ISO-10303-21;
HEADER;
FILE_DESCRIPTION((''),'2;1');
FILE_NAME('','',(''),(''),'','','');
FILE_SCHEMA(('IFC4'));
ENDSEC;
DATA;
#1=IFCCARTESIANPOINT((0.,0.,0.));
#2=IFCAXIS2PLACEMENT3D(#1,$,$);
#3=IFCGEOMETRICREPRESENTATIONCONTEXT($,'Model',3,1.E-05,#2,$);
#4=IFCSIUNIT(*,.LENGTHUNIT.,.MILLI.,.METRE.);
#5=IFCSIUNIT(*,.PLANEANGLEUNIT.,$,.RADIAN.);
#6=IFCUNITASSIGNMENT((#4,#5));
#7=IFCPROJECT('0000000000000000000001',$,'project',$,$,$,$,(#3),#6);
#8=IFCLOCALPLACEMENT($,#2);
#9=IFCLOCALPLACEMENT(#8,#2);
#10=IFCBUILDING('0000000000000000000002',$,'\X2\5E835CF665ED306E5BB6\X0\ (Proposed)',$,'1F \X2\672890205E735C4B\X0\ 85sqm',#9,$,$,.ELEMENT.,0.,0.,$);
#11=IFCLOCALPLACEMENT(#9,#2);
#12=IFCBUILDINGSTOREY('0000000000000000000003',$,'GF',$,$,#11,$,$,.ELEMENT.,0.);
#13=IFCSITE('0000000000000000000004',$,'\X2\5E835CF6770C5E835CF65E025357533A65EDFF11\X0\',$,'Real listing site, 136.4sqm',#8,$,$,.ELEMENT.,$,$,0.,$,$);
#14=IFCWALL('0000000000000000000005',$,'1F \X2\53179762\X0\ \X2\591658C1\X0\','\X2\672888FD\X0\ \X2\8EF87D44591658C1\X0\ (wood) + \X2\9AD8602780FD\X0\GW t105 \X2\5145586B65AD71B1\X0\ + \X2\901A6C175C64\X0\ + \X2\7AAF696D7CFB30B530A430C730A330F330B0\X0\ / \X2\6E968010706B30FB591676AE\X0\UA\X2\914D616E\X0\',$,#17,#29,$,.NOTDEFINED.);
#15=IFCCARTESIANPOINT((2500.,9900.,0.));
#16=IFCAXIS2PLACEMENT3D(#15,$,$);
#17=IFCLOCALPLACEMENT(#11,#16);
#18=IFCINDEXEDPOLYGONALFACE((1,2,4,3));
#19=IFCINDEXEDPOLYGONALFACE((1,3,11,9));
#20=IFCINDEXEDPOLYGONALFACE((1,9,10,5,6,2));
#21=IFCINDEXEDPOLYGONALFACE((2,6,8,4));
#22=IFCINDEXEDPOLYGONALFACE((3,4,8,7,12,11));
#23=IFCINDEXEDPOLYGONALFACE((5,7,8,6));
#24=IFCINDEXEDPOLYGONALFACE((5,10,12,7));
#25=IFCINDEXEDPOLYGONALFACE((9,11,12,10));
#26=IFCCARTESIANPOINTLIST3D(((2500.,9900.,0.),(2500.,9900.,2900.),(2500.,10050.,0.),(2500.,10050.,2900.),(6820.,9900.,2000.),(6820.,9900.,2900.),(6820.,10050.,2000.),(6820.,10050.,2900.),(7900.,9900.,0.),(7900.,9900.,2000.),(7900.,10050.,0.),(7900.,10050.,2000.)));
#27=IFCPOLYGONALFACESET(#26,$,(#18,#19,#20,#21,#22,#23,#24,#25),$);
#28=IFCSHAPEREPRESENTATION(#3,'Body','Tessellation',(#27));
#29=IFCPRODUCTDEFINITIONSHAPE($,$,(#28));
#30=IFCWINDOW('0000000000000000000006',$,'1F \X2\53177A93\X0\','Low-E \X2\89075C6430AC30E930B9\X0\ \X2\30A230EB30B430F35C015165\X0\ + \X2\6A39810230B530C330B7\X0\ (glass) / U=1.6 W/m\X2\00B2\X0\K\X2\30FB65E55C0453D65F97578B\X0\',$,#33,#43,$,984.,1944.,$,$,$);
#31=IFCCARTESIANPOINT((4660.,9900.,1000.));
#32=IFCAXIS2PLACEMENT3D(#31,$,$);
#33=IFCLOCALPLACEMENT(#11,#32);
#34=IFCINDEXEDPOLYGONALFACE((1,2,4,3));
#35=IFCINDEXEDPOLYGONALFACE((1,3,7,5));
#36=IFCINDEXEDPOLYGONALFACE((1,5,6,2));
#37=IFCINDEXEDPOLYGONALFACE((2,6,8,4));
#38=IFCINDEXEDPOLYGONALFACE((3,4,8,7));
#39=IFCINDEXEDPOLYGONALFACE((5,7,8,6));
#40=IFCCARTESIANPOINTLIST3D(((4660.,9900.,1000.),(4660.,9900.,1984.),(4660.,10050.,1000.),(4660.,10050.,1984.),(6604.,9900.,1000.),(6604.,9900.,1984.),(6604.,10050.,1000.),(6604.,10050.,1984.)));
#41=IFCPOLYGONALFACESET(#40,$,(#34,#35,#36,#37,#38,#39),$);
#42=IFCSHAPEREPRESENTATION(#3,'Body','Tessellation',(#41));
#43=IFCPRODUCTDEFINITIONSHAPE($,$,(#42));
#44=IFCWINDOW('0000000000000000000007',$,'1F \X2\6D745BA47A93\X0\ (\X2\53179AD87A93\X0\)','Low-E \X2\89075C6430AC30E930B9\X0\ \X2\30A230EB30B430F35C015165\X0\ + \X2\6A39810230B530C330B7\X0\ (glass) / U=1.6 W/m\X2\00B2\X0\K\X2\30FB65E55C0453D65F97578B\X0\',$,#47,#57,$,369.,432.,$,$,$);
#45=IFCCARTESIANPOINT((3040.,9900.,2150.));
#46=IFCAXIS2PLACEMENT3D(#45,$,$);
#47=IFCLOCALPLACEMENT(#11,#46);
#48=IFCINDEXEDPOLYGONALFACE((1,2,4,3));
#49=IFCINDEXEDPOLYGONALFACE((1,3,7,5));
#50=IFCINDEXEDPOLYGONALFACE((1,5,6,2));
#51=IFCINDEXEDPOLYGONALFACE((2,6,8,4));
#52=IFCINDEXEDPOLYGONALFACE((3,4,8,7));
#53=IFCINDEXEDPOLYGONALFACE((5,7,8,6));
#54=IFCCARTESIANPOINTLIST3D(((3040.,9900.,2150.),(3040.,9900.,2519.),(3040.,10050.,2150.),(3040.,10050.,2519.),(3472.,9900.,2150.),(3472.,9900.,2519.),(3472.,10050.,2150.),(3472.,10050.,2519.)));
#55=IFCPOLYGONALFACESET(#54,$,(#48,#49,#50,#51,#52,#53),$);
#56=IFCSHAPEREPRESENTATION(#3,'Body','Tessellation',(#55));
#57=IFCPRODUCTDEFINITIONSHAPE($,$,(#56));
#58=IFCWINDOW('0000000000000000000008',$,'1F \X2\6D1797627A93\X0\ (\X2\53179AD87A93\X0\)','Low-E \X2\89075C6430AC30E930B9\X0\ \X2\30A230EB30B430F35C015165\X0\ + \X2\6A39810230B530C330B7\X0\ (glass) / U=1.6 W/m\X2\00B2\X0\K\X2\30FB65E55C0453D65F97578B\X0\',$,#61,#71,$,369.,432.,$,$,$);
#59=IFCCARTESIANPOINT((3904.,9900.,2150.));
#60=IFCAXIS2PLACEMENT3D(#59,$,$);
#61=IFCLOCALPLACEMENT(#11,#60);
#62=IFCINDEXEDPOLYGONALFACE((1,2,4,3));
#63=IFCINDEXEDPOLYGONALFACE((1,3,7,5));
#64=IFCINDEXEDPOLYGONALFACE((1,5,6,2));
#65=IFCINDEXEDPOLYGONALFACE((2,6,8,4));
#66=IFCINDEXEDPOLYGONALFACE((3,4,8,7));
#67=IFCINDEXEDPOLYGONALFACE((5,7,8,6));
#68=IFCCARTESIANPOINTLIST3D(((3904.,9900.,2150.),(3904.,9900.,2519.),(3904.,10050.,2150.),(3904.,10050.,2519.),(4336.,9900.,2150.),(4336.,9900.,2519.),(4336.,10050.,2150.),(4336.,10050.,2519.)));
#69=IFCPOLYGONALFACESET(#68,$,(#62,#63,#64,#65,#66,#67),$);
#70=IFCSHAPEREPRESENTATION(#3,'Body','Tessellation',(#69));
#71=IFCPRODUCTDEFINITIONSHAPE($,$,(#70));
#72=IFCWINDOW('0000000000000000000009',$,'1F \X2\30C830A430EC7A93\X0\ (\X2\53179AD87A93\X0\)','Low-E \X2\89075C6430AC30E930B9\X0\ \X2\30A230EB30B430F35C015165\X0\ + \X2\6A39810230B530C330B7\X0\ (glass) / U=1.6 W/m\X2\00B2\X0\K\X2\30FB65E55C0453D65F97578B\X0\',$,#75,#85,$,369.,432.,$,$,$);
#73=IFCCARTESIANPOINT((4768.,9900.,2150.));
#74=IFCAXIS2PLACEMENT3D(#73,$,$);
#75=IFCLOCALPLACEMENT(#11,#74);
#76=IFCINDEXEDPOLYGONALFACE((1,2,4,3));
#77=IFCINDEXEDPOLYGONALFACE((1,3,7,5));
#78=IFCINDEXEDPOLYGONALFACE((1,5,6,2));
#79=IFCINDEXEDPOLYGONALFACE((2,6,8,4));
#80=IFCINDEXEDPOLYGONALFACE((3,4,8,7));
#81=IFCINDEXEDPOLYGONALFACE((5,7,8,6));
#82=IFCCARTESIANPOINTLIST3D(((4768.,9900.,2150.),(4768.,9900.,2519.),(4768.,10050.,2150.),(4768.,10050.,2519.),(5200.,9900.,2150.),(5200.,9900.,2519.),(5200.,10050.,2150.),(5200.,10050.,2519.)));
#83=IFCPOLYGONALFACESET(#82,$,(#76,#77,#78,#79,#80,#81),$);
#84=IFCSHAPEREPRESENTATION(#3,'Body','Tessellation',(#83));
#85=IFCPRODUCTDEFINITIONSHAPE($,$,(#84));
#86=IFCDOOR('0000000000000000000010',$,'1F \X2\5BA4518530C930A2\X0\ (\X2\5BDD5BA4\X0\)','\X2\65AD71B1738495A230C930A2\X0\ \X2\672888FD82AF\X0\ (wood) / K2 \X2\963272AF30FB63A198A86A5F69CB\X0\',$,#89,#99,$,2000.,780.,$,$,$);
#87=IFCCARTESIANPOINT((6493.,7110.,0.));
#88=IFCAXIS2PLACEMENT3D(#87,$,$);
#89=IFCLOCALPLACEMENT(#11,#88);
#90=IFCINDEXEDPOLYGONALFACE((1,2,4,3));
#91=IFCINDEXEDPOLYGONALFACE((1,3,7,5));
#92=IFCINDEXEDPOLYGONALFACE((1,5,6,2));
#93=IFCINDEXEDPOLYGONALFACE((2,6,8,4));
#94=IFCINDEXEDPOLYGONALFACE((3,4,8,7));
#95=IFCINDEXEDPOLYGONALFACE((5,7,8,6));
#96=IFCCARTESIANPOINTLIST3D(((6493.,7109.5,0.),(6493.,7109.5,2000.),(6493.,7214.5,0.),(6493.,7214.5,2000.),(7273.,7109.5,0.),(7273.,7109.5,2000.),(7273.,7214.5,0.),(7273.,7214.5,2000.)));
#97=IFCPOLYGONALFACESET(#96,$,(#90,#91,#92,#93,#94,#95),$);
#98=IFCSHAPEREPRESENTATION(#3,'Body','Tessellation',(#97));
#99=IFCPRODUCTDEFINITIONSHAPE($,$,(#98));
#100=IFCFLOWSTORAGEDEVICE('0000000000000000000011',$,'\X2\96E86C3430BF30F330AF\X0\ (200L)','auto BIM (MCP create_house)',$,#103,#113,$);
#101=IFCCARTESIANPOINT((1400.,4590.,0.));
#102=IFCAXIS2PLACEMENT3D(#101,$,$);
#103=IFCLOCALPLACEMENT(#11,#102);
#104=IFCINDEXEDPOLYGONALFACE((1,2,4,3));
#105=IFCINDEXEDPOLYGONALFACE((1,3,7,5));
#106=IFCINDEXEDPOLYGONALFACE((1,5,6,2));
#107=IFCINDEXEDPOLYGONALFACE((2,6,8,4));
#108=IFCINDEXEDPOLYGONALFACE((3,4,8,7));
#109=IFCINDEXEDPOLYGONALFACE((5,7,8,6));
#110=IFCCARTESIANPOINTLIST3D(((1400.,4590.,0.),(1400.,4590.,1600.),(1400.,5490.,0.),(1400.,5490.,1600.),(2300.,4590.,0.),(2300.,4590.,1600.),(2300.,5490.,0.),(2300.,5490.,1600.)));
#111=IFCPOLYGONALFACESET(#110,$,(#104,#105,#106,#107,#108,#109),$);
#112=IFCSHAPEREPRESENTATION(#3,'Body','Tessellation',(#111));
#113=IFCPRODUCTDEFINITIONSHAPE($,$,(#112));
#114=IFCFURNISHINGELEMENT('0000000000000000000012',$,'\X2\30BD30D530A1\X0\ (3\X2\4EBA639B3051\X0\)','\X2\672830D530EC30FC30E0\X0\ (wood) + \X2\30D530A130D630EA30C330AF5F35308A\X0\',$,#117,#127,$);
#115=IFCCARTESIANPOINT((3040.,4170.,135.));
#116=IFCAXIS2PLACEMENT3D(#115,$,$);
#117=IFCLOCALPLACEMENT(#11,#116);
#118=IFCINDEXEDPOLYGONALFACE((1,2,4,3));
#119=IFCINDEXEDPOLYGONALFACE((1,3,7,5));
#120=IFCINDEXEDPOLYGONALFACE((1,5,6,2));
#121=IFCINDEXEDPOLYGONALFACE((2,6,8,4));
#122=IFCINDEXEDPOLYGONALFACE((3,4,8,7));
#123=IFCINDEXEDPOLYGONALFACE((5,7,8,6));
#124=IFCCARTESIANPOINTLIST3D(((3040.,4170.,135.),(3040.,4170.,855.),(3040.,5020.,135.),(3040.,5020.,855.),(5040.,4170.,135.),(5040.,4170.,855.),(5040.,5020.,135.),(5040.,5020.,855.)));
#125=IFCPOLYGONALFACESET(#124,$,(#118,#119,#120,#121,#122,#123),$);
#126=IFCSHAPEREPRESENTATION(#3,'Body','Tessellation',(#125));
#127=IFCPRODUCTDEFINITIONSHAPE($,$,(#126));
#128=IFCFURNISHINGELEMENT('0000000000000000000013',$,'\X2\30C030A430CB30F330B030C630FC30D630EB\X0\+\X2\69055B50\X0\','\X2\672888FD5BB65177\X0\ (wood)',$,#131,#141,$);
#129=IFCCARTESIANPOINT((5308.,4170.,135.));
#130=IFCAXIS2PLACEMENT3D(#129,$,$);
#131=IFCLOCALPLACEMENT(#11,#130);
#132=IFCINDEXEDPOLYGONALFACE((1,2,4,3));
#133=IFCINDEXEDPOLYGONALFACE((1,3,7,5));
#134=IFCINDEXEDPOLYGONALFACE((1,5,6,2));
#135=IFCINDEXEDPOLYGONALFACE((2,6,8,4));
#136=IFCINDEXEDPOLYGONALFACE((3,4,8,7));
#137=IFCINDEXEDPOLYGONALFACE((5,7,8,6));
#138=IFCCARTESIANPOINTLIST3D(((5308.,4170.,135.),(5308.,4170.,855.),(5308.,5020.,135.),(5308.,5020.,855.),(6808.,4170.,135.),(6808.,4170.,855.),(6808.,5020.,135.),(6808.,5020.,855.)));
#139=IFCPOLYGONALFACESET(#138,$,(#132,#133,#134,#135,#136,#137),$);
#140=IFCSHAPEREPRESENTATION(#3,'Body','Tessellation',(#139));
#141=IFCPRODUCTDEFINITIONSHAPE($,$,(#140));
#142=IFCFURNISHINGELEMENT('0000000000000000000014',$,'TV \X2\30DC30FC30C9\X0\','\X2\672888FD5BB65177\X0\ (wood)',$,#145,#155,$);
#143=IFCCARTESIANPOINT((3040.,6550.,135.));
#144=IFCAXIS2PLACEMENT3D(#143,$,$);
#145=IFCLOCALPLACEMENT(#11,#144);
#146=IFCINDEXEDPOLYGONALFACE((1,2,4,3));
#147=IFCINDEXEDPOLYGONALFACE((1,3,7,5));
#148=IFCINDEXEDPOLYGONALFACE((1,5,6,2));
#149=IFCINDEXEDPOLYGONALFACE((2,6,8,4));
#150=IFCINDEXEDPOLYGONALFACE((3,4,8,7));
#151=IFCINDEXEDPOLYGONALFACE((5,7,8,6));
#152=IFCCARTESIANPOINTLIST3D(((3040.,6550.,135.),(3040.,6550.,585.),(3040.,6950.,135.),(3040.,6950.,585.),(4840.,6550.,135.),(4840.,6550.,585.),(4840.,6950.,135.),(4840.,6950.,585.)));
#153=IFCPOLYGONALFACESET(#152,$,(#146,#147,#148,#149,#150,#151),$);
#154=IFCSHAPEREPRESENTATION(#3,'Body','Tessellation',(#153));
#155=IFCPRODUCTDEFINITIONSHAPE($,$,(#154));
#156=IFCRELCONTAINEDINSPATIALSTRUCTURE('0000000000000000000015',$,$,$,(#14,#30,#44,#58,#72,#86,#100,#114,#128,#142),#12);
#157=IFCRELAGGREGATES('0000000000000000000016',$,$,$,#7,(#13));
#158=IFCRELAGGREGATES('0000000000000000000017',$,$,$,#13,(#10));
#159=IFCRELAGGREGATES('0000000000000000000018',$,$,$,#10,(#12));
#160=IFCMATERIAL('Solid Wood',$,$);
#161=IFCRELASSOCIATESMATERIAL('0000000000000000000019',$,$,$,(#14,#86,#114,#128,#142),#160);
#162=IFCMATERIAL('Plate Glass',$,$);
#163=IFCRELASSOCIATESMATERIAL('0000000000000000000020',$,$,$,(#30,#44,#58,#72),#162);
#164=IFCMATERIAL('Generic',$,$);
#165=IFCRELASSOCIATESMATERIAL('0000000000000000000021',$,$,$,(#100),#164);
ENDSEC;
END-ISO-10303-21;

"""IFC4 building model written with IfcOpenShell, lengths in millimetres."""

from ifc_helpers import new_model, si_unit, frame, frame_2d, origin, place, context, project, spatial, rectangle, extrude, material, element, fill, save


model = new_model("IFC4")

# Units and contexts
model_context = context("Model", 3, precision=1e-05, world=origin())
ifc_project = project(units=[si_unit("LENGTHUNIT", "METRE", prefix="MILLI"), si_unit("PLANEANGLEUNIT", "RADIAN")], contexts=[model_context])

# Site, building, storey
site_placement = place(None, origin())
site = spatial("IfcSite", under=ifc_project, at=site_placement, Name="広島県広島市南区旭１", ObjectType="Real listing site, 136.4sqm", CompositionType="ELEMENT", RefElevation=0.0)
building_placement = place(site_placement, origin())
building = spatial("IfcBuilding", under=site, at=building_placement, Name="広島旭の家 (Proposed)", ObjectType="1F 木造平屋 85sqm", CompositionType="ELEMENT", ElevationOfRefHeight=0.0, ElevationOfTerrain=0.0)
storey_placement = place(building_placement, origin())
storey = spatial("IfcBuildingStorey", under=building, at=storey_placement, Name="GF", CompositionType="ELEMENT", Elevation=0.0)

# Wall, openings, windows
ifc_material_1 = material(Name="Solid Wood")
wall_1_placement = place(storey_placement, frame((2500.0, 9900.0, 0.0)))
wall_1 = element("IfcWall", 1, at=wall_1_placement, inside=storey, material=ifc_material_1, Name="1F 北面 外壁", Description="木製 軸組外壁 (wood) + 高性能GW t105 充填断熱 + 通気層 + 窯業系サイディング / 準耐火・外皮UA配慮", PredefinedType="NOTDEFINED", context=model_context, shape_type="SweptSolid", body=[
    extrude(rectangle(XDim=5400.0, YDim=150.0, at=frame_2d((2700.0, 75.0))), frame((2500.0, 9900.0, 0.0)), (0.0, 0.0, 1.0), 2900.0),
])
opening_1_placement = place(storey_placement, frame((4660.0, 9900.0, 1000.0)))
opening_1 = element("IfcOpeningElement", 2, at=opening_1_placement, cuts=wall_1, PredefinedType="NOTDEFINED", context=model_context, shape_type="SweptSolid", body=[
    extrude(rectangle(XDim=1944.0, YDim=150.0, at=frame_2d((972.0, 75.0))), frame((4660.0, 9900.0, 1000.0)), (0.0, 0.0, 1.0), 984.0),
])
opening_2_placement = place(storey_placement, frame((3040.0, 9900.0, 2150.0)))
opening_2 = element("IfcOpeningElement", 3, at=opening_2_placement, cuts=wall_1, PredefinedType="NOTDEFINED", context=model_context, shape_type="SweptSolid", body=[
    extrude(rectangle(XDim=432.0, YDim=150.0, at=frame_2d((216.0, 75.0))), frame((3040.0, 9900.0, 2150.0)), (0.0, 0.0, 1.0), 369.0),
])
opening_3_placement = place(storey_placement, frame((3904.0, 9900.0, 2150.0)))
opening_3 = element("IfcOpeningElement", 4, at=opening_3_placement, cuts=wall_1, PredefinedType="NOTDEFINED", context=model_context, shape_type="SweptSolid", body=[
    extrude(rectangle(XDim=432.0, YDim=150.0, at=frame_2d((216.0, 75.0))), frame((3904.0, 9900.0, 2150.0)), (0.0, 0.0, 1.0), 369.0),
])
opening_4_placement = place(storey_placement, frame((4768.0, 9900.0, 2150.0)))
opening_4 = element("IfcOpeningElement", 5, at=opening_4_placement, cuts=wall_1, PredefinedType="NOTDEFINED", context=model_context, shape_type="SweptSolid", body=[
    extrude(rectangle(XDim=432.0, YDim=150.0, at=frame_2d((216.0, 75.0))), frame((4768.0, 9900.0, 2150.0)), (0.0, 0.0, 1.0), 369.0),
])
ifc_material_2 = material(Name="Plate Glass")
window_1_placement = place(storey_placement, frame((4660.0, 9900.0, 1000.0)))
window_1 = element("IfcWindow", 6, at=window_1_placement, inside=storey, material=ifc_material_2, Name="1F 北窓", Description="Low-E 複層ガラス アルゴン封入 + 樹脂サッシ (glass) / U=1.6 W/m²K・日射取得型", OverallHeight=984.0, OverallWidth=1944.0, context=model_context, shape_type="SweptSolid", body=[
    extrude(rectangle(XDim=1944.0, YDim=150.0, at=frame_2d((972.0, 75.0))), frame((4660.0, 9900.0, 1000.0)), (0.0, 0.0, 1.0), 984.0),
])
fill(opening_1, window_1)
window_2_placement = place(storey_placement, frame((3040.0, 9900.0, 2150.0)))
window_2 = element("IfcWindow", 7, at=window_2_placement, inside=storey, material=ifc_material_2, Name="1F 浴室窓 (北高窓)", Description="Low-E 複層ガラス アルゴン封入 + 樹脂サッシ (glass) / U=1.6 W/m²K・日射取得型", OverallHeight=369.0, OverallWidth=432.0, context=model_context, shape_type="SweptSolid", body=[
    extrude(rectangle(XDim=432.0, YDim=150.0, at=frame_2d((216.0, 75.0))), frame((3040.0, 9900.0, 2150.0)), (0.0, 0.0, 1.0), 369.0),
])
fill(opening_2, window_2)
window_3_placement = place(storey_placement, frame((3904.0, 9900.0, 2150.0)))
window_3 = element("IfcWindow", 8, at=window_3_placement, inside=storey, material=ifc_material_2, Name="1F 洗面窓 (北高窓)", Description="Low-E 複層ガラス アルゴン封入 + 樹脂サッシ (glass) / U=1.6 W/m²K・日射取得型", OverallHeight=369.0, OverallWidth=432.0, context=model_context, shape_type="SweptSolid", body=[
    extrude(rectangle(XDim=432.0, YDim=150.0, at=frame_2d((216.0, 75.0))), frame((3904.0, 9900.0, 2150.0)), (0.0, 0.0, 1.0), 369.0),
])
fill(opening_3, window_3)
window_4_placement = place(storey_placement, frame((4768.0, 9900.0, 2150.0)))
window_4 = element("IfcWindow", 9, at=window_4_placement, inside=storey, material=ifc_material_2, Name="1F トイレ窓 (北高窓)", Description="Low-E 複層ガラス アルゴン封入 + 樹脂サッシ (glass) / U=1.6 W/m²K・日射取得型", OverallHeight=369.0, OverallWidth=432.0, context=model_context, shape_type="SweptSolid", body=[
    extrude(rectangle(XDim=432.0, YDim=150.0, at=frame_2d((216.0, 75.0))), frame((4768.0, 9900.0, 2150.0)), (0.0, 0.0, 1.0), 369.0),
])
fill(opening_4, window_4)

# Door
door_1_placement = place(storey_placement, frame((6493.0, 7110.0, 0.0)))
element("IfcDoor", 10, at=door_1_placement, inside=storey, material=ifc_material_1, Name="1F 室内ドア (寝室)", Description="断熱玄関ドア 木製芯 (wood) / K2 防犯・採風機構", OverallHeight=2000.0, OverallWidth=780.0, context=model_context, shape_type="SweptSolid", body=[
    extrude(rectangle(XDim=780.0, YDim=105.0, at=frame_2d((390.0, 52.0))), frame((6493.0, 7110.0, 0.0)), (0.0, 0.0, 1.0), 2000.0),
])

# Flow storage device
ifc_material_3 = material(Name="Generic")
flow_storage_device_placement = place(storey_placement, frame((1400.0, 4590.0, 0.0)))
element("IfcFlowStorageDevice", 11, at=flow_storage_device_placement, inside=storey, material=ifc_material_3, Name="雨水タンク (200L)", Description="auto BIM (MCP create_house)", context=model_context, shape_type="SweptSolid", body=[
    extrude(rectangle(XDim=900.0, YDim=900.0, at=frame_2d((450.0, 450.0))), frame((1400.0, 4590.0, 0.0)), (0.0, 0.0, 1.0), 1600.0),
])

# Furnishing elements
furnishing_1_placement = place(storey_placement, frame((3040.0, 4170.0, 135.0)))
element("IfcFurnishingElement", 12, at=furnishing_1_placement, inside=storey, material=ifc_material_1, Name="ソファ (3人掛け)", Description="木フレーム (wood) + ファブリック張り", context=model_context, shape_type="SweptSolid", body=[
    extrude(rectangle(XDim=2000.0, YDim=850.0, at=frame_2d((1000.0, 425.0))), frame((3040.0, 4170.0, 135.0)), (0.0, 0.0, 1.0), 720.0),
])
furnishing_2_placement = place(storey_placement, frame((5308.0, 4170.0, 135.0)))
element("IfcFurnishingElement", 13, at=furnishing_2_placement, inside=storey, material=ifc_material_1, Name="ダイニングテーブル+椅子", Description="木製家具 (wood)", context=model_context, shape_type="SweptSolid", body=[
    extrude(rectangle(XDim=1500.0, YDim=850.0, at=frame_2d((750.0, 425.0))), frame((5308.0, 4170.0, 135.0)), (0.0, 0.0, 1.0), 720.0),
])
furnishing_3_placement = place(storey_placement, frame((3040.0, 6550.0, 135.0)))
element("IfcFurnishingElement", 14, at=furnishing_3_placement, inside=storey, material=ifc_material_1, Name="TV ボード", Description="木製家具 (wood)", context=model_context, shape_type="SweptSolid", body=[
    extrude(rectangle(XDim=1800.0, YDim=400.0, at=frame_2d((900.0, 200.0))), frame((3040.0, 6550.0, 135.0)), (0.0, 0.0, 1.0), 450.0),
])

save(model, "model.ifc")
